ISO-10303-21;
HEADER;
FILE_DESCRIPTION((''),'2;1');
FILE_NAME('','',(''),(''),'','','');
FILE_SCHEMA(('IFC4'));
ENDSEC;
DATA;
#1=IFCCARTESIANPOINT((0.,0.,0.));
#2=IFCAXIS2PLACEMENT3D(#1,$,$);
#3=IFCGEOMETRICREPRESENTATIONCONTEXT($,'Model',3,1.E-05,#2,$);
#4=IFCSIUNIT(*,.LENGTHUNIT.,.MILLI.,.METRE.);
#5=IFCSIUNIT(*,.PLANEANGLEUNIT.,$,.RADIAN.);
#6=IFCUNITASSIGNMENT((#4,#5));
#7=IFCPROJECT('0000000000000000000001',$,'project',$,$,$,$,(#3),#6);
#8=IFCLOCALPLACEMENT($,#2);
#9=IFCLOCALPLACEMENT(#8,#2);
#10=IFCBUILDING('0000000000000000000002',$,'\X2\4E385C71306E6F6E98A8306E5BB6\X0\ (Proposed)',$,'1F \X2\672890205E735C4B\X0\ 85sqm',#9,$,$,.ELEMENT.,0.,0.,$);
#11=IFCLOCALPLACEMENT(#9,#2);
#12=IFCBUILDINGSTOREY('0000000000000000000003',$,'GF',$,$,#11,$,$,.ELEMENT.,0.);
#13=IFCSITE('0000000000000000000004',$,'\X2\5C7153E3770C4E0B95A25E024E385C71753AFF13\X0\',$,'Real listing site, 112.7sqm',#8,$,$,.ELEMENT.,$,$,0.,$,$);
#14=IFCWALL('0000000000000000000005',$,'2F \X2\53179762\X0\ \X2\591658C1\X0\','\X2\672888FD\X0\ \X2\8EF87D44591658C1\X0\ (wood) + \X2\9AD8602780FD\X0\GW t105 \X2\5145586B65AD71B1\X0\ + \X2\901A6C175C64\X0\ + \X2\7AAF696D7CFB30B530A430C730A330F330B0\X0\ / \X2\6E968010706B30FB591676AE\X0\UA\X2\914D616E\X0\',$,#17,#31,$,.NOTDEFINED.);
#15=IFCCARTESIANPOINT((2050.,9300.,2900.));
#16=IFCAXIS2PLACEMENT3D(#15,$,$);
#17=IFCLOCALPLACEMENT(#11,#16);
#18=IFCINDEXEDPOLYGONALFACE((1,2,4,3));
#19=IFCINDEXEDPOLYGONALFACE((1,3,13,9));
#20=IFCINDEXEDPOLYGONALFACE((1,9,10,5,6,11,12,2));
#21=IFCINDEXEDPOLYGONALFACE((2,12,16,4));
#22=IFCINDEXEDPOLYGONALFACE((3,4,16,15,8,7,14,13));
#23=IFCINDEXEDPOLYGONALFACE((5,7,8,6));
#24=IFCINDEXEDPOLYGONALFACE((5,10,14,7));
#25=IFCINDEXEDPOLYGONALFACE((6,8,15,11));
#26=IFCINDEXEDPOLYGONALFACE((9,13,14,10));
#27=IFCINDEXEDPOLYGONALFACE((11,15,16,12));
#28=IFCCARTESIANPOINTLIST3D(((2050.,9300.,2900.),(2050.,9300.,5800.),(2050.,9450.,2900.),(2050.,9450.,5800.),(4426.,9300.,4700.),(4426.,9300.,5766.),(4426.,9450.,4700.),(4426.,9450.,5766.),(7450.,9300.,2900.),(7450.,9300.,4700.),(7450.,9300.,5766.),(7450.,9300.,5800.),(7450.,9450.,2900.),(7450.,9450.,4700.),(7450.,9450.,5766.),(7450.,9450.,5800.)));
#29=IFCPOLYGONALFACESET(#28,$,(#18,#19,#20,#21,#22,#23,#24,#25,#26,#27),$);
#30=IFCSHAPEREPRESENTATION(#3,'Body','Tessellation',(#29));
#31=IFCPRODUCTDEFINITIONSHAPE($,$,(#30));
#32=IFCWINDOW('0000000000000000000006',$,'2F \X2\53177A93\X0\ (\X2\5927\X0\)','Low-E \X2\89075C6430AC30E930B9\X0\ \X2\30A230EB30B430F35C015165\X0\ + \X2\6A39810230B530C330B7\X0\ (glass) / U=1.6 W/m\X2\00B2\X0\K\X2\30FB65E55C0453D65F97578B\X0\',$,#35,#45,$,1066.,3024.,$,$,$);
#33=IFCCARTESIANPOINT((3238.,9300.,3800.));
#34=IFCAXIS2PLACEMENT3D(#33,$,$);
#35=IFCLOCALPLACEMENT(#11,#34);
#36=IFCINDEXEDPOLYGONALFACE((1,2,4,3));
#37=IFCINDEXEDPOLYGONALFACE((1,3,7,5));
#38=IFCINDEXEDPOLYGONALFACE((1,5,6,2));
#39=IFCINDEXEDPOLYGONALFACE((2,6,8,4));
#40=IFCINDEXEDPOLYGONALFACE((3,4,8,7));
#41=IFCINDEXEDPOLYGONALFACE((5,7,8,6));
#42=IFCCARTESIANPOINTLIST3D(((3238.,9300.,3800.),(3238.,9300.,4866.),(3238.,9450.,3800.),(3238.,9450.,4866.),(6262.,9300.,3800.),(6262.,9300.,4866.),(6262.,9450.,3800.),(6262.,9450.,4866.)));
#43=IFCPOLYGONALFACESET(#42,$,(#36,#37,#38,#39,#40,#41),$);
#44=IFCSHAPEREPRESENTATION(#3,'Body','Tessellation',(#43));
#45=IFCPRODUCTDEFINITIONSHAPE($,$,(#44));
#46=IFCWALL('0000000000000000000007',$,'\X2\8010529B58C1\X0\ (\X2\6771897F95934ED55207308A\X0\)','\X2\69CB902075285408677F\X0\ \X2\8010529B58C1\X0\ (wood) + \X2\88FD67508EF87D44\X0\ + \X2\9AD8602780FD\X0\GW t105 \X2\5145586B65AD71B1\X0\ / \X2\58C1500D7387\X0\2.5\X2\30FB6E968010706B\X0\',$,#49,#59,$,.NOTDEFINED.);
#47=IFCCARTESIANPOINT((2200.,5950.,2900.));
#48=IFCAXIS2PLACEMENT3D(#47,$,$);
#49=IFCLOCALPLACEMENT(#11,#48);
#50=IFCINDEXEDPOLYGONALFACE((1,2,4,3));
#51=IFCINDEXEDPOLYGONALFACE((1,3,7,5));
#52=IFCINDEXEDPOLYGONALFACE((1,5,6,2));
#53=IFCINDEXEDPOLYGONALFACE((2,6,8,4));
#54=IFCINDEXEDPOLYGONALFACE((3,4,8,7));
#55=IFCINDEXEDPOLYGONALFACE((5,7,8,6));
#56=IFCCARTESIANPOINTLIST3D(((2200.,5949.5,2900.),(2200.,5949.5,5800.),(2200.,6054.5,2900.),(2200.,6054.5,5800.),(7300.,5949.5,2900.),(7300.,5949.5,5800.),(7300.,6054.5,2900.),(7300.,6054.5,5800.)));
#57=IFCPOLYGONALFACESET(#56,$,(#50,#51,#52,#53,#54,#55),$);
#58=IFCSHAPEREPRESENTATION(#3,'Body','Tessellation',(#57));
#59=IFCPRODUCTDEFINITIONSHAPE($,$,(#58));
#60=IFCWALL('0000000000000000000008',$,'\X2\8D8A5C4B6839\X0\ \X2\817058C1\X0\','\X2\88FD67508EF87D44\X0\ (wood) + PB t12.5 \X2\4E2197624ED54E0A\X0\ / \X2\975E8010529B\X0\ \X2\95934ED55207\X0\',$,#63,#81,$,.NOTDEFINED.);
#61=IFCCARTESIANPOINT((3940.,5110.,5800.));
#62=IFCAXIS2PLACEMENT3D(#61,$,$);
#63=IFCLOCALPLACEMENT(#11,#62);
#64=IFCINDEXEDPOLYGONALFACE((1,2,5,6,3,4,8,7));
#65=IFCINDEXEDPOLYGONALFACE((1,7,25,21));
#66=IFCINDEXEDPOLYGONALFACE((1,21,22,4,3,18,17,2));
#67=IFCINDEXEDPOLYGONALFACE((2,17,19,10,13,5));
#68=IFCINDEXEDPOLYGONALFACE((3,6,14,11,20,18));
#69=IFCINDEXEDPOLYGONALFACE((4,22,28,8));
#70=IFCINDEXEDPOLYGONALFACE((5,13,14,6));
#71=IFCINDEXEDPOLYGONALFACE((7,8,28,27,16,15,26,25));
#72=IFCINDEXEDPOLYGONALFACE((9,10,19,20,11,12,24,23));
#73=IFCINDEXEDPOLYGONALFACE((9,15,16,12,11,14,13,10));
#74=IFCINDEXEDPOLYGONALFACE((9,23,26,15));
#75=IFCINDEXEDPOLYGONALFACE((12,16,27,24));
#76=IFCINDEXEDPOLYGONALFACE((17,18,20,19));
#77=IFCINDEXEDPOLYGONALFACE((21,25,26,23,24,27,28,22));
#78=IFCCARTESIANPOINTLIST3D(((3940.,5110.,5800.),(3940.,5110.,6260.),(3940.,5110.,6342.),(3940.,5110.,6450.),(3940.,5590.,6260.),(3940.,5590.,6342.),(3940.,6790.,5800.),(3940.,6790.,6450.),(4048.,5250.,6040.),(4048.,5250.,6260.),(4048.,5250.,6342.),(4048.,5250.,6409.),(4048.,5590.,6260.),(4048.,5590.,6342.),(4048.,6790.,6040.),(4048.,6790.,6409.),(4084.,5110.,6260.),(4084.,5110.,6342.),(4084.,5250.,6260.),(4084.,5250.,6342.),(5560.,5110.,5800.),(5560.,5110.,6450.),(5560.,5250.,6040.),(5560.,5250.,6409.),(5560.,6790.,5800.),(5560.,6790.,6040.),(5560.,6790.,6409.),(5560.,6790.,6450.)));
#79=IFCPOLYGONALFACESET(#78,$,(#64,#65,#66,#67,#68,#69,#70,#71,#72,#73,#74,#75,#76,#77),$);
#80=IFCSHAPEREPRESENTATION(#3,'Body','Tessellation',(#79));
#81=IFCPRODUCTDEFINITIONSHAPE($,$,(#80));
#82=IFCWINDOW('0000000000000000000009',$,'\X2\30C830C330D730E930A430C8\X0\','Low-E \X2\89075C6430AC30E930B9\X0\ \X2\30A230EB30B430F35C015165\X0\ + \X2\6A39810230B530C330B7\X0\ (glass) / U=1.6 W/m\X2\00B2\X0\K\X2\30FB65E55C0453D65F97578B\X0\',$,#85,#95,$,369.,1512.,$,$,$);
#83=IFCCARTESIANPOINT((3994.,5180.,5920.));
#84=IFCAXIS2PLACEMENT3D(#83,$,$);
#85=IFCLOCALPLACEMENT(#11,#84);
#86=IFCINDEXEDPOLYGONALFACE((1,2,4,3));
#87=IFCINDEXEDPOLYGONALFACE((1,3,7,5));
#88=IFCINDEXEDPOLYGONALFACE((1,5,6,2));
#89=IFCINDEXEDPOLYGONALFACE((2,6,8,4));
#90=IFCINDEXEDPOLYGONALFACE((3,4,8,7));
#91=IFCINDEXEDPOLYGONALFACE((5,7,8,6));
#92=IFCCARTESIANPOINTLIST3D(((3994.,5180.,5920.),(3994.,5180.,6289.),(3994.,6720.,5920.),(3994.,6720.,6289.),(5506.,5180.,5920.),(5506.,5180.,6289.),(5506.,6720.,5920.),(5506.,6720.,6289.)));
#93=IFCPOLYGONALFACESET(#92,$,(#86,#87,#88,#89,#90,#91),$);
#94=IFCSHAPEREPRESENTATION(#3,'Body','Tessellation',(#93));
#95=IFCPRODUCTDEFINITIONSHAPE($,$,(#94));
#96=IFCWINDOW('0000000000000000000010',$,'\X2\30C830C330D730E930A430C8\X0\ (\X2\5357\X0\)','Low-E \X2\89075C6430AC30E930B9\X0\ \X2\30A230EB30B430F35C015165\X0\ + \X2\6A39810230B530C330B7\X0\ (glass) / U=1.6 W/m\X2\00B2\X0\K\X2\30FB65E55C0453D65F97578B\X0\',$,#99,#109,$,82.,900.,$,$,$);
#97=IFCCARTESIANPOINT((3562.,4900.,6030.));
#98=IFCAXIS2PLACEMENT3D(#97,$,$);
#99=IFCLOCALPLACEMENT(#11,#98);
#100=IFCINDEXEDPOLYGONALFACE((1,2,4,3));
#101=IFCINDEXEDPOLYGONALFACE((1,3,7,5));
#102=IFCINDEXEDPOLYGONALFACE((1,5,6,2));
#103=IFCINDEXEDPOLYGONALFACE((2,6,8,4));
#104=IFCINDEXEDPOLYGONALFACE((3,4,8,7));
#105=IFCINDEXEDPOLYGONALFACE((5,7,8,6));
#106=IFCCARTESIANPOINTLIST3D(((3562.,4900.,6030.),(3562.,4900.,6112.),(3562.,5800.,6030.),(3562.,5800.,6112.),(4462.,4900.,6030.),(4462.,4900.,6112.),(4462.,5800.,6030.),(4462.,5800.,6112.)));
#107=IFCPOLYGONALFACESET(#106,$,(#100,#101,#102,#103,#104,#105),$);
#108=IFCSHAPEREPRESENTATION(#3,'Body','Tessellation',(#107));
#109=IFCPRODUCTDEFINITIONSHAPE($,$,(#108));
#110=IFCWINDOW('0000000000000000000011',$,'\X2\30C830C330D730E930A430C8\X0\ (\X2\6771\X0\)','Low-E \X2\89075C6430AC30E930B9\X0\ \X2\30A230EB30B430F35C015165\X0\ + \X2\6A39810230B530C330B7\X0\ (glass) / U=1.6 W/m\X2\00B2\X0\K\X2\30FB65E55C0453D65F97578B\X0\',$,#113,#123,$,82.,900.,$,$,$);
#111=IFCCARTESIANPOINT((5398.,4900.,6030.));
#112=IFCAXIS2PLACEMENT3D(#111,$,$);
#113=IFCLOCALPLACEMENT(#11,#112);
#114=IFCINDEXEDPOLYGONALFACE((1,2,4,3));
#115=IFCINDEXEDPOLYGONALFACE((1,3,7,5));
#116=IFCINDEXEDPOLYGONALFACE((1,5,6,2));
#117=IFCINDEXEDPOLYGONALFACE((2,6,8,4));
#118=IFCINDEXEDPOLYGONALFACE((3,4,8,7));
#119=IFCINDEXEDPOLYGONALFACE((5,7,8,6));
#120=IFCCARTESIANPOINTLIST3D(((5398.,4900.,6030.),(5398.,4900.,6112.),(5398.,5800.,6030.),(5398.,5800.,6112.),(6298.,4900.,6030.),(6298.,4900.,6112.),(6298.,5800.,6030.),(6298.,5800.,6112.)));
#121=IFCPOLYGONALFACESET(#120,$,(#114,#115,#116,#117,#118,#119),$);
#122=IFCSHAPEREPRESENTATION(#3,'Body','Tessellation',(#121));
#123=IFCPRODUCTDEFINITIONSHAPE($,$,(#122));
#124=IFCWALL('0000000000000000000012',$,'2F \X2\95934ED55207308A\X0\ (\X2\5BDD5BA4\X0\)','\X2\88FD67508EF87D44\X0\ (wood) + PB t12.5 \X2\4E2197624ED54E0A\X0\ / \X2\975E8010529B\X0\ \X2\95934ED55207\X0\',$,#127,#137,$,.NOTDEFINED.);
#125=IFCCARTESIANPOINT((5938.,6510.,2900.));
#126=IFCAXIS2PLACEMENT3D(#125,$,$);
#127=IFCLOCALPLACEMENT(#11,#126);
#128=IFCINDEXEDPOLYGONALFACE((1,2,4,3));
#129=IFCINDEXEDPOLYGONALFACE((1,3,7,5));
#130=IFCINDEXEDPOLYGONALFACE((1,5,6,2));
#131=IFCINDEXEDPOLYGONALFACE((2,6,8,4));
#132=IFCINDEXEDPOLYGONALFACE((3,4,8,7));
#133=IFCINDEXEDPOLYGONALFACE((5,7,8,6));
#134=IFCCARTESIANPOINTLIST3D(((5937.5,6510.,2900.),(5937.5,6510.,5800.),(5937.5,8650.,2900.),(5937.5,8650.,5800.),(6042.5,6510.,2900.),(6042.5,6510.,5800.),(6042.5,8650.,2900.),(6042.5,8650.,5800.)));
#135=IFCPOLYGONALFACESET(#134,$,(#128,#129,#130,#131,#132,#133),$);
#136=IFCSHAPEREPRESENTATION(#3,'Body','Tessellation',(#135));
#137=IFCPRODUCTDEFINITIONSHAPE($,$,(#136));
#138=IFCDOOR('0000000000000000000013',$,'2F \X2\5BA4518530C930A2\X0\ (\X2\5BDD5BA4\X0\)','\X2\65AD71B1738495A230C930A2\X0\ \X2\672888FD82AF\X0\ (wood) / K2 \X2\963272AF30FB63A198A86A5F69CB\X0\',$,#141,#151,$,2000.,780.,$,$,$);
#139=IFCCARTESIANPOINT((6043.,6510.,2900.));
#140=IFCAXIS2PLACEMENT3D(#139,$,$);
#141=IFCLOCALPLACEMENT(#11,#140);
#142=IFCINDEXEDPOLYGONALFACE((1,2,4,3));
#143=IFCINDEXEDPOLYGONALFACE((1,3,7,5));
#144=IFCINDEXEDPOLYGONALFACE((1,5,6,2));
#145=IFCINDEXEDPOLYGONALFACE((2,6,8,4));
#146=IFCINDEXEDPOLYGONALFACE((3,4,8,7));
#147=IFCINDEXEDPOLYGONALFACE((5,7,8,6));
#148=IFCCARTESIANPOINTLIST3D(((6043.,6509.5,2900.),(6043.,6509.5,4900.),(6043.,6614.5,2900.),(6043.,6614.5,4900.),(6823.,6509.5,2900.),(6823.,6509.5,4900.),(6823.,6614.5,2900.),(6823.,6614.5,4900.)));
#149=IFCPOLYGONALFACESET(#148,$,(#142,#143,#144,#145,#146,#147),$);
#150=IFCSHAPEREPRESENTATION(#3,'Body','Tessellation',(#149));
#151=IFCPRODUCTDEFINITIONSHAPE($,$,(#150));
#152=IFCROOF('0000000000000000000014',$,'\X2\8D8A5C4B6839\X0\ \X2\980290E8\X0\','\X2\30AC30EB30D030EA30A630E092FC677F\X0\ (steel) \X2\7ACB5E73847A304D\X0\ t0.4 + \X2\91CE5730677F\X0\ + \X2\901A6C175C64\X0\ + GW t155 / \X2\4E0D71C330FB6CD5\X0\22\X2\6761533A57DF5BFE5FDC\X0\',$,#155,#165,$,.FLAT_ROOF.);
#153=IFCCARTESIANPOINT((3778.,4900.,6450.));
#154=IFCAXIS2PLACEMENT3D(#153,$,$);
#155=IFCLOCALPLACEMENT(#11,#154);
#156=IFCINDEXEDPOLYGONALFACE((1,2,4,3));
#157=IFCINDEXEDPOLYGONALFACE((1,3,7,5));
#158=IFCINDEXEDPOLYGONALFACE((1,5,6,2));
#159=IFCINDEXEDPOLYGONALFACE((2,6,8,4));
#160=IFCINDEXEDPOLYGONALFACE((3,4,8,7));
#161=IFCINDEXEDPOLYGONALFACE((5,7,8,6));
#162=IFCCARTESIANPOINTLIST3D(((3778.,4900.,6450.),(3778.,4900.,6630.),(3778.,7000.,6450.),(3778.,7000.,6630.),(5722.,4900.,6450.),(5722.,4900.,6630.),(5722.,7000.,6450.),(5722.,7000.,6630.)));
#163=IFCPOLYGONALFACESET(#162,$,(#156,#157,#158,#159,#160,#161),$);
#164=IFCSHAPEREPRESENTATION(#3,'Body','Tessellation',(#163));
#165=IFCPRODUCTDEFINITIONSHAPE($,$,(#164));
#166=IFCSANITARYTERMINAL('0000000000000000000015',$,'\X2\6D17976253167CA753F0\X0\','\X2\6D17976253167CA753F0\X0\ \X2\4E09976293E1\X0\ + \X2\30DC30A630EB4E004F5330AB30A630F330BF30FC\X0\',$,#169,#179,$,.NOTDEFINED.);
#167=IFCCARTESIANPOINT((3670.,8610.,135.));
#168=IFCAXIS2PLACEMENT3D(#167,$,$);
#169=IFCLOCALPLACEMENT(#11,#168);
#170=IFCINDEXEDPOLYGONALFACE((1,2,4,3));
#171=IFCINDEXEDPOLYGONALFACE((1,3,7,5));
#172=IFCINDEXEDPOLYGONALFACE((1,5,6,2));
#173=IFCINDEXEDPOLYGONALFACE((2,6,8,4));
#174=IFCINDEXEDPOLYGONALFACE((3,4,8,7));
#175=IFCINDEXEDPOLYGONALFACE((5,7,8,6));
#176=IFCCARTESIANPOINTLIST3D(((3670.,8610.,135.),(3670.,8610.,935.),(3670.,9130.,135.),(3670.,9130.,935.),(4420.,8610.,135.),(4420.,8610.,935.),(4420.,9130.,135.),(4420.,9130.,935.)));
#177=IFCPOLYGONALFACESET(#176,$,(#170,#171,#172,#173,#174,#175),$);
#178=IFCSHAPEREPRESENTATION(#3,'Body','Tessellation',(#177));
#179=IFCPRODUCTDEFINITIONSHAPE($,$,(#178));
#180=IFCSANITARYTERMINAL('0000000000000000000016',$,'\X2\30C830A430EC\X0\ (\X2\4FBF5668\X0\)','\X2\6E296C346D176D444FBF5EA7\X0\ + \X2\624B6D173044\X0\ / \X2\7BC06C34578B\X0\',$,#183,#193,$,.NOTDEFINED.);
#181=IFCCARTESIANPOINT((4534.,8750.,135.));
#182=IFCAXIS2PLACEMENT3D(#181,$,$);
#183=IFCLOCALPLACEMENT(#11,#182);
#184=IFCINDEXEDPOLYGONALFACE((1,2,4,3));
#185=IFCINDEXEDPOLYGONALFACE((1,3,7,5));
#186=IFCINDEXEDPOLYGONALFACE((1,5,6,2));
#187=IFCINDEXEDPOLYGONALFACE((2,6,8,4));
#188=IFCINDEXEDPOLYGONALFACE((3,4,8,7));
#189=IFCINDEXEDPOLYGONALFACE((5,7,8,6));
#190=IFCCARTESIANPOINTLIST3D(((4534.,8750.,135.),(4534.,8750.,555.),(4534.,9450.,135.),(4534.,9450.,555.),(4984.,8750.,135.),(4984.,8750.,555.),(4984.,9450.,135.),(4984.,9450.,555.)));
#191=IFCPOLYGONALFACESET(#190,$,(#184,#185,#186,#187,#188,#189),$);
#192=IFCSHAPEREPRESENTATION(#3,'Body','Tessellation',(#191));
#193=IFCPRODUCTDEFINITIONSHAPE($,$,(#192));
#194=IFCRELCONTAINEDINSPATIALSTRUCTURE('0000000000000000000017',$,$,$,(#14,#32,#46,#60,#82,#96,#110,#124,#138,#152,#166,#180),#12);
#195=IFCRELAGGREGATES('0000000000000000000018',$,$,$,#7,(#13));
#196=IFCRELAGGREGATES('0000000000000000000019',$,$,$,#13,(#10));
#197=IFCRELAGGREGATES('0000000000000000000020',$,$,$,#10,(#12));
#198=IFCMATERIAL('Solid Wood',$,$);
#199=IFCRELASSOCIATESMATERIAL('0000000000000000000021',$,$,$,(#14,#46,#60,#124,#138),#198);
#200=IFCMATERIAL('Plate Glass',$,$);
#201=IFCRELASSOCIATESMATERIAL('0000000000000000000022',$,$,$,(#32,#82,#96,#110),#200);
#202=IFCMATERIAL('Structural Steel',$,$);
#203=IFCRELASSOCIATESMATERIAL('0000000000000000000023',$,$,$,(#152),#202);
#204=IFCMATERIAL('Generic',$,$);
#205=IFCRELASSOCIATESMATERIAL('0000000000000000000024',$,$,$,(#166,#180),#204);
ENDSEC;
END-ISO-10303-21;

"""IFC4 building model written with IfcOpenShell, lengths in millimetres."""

from ifc_helpers import new_model, si_unit, frame, frame_2d, origin, place, context, project, spatial, rectangle, extrude, material, element, fill, save


model = new_model("IFC4")

# Units and contexts
model_context = context("Model", 3, precision=1e-05, world=origin())
ifc_project = project(units=[si_unit("LENGTHUNIT", "METRE", prefix="MILLI"), si_unit("PLANEANGLEUNIT", "RADIAN")], contexts=[model_context])

# Site, building, storey
site_placement = place(None, origin())
site = spatial("IfcSite", under=ifc_project, at=site_placement, Name="山口県下関市丸山町３", ObjectType="Real listing site, 112.7sqm", CompositionType="ELEMENT", RefElevation=0.0)
building_placement = place(site_placement, origin())
building = spatial("IfcBuilding", under=site, at=building_placement, Name="丸山の潮風の家 (Proposed)", ObjectType="1F 木造平屋 85sqm", CompositionType="ELEMENT", ElevationOfRefHeight=0.0, ElevationOfTerrain=0.0)
storey_placement = place(building_placement, origin())
storey = spatial("IfcBuildingStorey", under=building, at=storey_placement, Name="GF", CompositionType="ELEMENT", Elevation=0.0)

# Wall, opening, window
ifc_material_1 = material(Name="Solid Wood")
wall_1_placement = place(storey_placement, frame((2050.0, 9300.0, 2900.0)))
wall_1 = element("IfcWall", 1, at=wall_1_placement, inside=storey, material=ifc_material_1, Name="2F 北面 外壁", Description="木製 軸組外壁 (wood) + 高性能GW t105 充填断熱 + 通気層 + 窯業系サイディング / 準耐火・外皮UA配慮", PredefinedType="NOTDEFINED", context=model_context, shape_type="SweptSolid", body=[
    extrude(rectangle(XDim=5400.0, YDim=150.0, at=frame_2d((2700.0, 75.0))), frame((2050.0, 9300.0, 2900.0)), (0.0, 0.0, 1.0), 2900.0),
])
opening_1_placement = place(storey_placement, frame((3238.0, 9300.0, 3800.0)))
opening_1 = element("IfcOpeningElement", 2, at=opening_1_placement, cuts=wall_1, PredefinedType="NOTDEFINED", context=model_context, shape_type="SweptSolid", body=[
    extrude(rectangle(XDim=3024.0, YDim=150.0, at=frame_2d((1512.0, 75.0))), frame((3238.0, 9300.0, 3800.0)), (0.0, 0.0, 1.0), 1066.0),
])
ifc_material_2 = material(Name="Plate Glass")
window_1_placement = place(storey_placement, frame((3238.0, 9300.0, 3800.0)))
window_1 = element("IfcWindow", 3, at=window_1_placement, inside=storey, material=ifc_material_2, Name="2F 北窓 (大)", Description="Low-E 複層ガラス アルゴン封入 + 樹脂サッシ (glass) / U=1.6 W/m²K・日射取得型", OverallHeight=1066.0, OverallWidth=3024.0, context=model_context, shape_type="SweptSolid", body=[
    extrude(rectangle(XDim=3024.0, YDim=150.0, at=frame_2d((1512.0, 75.0))), frame((3238.0, 9300.0, 3800.0)), (0.0, 0.0, 1.0), 1066.0),
])
fill(opening_1, window_1)

# Wall
wall_2_placement = place(storey_placement, frame((2200.0, 5950.0, 2900.0)))
element("IfcWall", 4, at=wall_2_placement, inside=storey, material=ifc_material_1, Name="耐力壁 (東西間仕切り)", Description="構造用合板 耐力壁 (wood) + 製材軸組 + 高性能GW t105 充填断熱 / 壁倍率2.5・準耐火", PredefinedType="NOTDEFINED", context=model_context, shape_type="SweptSolid", body=[
    extrude(rectangle(XDim=5100.0, YDim=105.0, at=frame_2d((2550.0, 52.0))), frame((2200.0, 5950.0, 2900.0)), (0.0, 0.0, 1.0), 2900.0),
])

# Wall, openings, windows
wall_3_placement = place(storey_placement, frame((3940.0, 5110.0, 5800.0)))
wall_3 = element("IfcWall", 5, at=wall_3_placement, inside=storey, material=ifc_material_1, Name="越屋根 腰壁", Description="製材軸組 (wood) + PB t12.5 両面仕上 / 非耐力 間仕切", PredefinedType="NOTDEFINED", context=model_context, shape_type="SweptSolid", body=[
    extrude(rectangle(XDim=1620.0, YDim=1680.0, at=frame_2d((810.0, 840.0))), frame((3940.0, 5110.0, 5800.0)), (0.0, 0.0, 1.0), 650.0),
])
opening_2_placement = place(storey_placement, frame((3994.0, 5180.0, 5920.0)))
opening_2 = element("IfcOpeningElement", 6, at=opening_2_placement, cuts=wall_3, PredefinedType="NOTDEFINED", context=model_context, shape_type="SweptSolid", body=[
    extrude(rectangle(XDim=1512.0, YDim=1540.0, at=frame_2d((756.0, 770.0))), frame((3994.0, 5180.0, 5920.0)), (0.0, 0.0, 1.0), 369.0),
])
opening_3_placement = place(storey_placement, frame((3562.0, 4900.0, 6030.0)))
opening_3 = element("IfcOpeningElement", 7, at=opening_3_placement, cuts=wall_3, PredefinedType="NOTDEFINED", context=model_context, shape_type="SweptSolid", body=[
    extrude(rectangle(XDim=900.0, YDim=900.0, at=frame_2d((450.0, 450.0))), frame((3562.0, 4900.0, 6030.0)), (0.0, 0.0, 1.0), 82.0),
])
opening_4_placement = place(storey_placement, frame((5398.0, 4900.0, 6030.0)))
opening_4 = element("IfcOpeningElement", 8, at=opening_4_placement, cuts=wall_3, PredefinedType="NOTDEFINED", context=model_context, shape_type="SweptSolid", body=[
    extrude(rectangle(XDim=900.0, YDim=900.0, at=frame_2d((450.0, 450.0))), frame((5398.0, 4900.0, 6030.0)), (0.0, 0.0, 1.0), 82.0),
])
window_2_placement = place(storey_placement, frame((3994.0, 5180.0, 5920.0)))
window_2 = element("IfcWindow", 9, at=window_2_placement, inside=storey, material=ifc_material_2, Name="トップライト", Description="Low-E 複層ガラス アルゴン封入 + 樹脂サッシ (glass) / U=1.6 W/m²K・日射取得型", OverallHeight=369.0, OverallWidth=1512.0, context=model_context, shape_type="SweptSolid", body=[
    extrude(rectangle(XDim=1512.0, YDim=1540.0, at=frame_2d((756.0, 770.0))), frame((3994.0, 5180.0, 5920.0)), (0.0, 0.0, 1.0), 369.0),
])
fill(opening_2, window_2)
window_3_placement = place(storey_placement, frame((3562.0, 4900.0, 6030.0)))
window_3 = element("IfcWindow", 10, at=window_3_placement, inside=storey, material=ifc_material_2, Name="トップライト (南)", Description="Low-E 複層ガラス アルゴン封入 + 樹脂サッシ (glass) / U=1.6 W/m²K・日射取得型", OverallHeight=82.0, OverallWidth=900.0, context=model_context, shape_type="SweptSolid", body=[
    extrude(rectangle(XDim=900.0, YDim=900.0, at=frame_2d((450.0, 450.0))), frame((3562.0, 4900.0, 6030.0)), (0.0, 0.0, 1.0), 82.0),
])
fill(opening_3, window_3)
window_4_placement = place(storey_placement, frame((5398.0, 4900.0, 6030.0)))
window_4 = element("IfcWindow", 11, at=window_4_placement, inside=storey, material=ifc_material_2, Name="トップライト (東)", Description="Low-E 複層ガラス アルゴン封入 + 樹脂サッシ (glass) / U=1.6 W/m²K・日射取得型", OverallHeight=82.0, OverallWidth=900.0, context=model_context, shape_type="SweptSolid", body=[
    extrude(rectangle(XDim=900.0, YDim=900.0, at=frame_2d((450.0, 450.0))), frame((5398.0, 4900.0, 6030.0)), (0.0, 0.0, 1.0), 82.0),
])
fill(opening_4, window_4)

# Wall
wall_4_placement = place(storey_placement, frame((5938.0, 6510.0, 2900.0)))
element("IfcWall", 12, at=wall_4_placement, inside=storey, material=ifc_material_1, Name="2F 間仕切り (寝室)", Description="製材軸組 (wood) + PB t12.5 両面仕上 / 非耐力 間仕切", PredefinedType="NOTDEFINED", context=model_context, shape_type="SweptSolid", body=[
    extrude(rectangle(XDim=105.0, YDim=2140.0, at=frame_2d((52.0, 1070.0))), frame((5938.0, 6510.0, 2900.0)), (0.0, 0.0, 1.0), 2900.0),
])

# Door
door_placement = place(storey_placement, frame((6043.0, 6510.0, 2900.0)))
element("IfcDoor", 13, at=door_placement, inside=storey, material=ifc_material_1, Name="2F 室内ドア (寝室)", Description="断熱玄関ドア 木製芯 (wood) / K2 防犯・採風機構", OverallHeight=2000.0, OverallWidth=780.0, context=model_context, shape_type="SweptSolid", body=[
    extrude(rectangle(XDim=780.0, YDim=105.0, at=frame_2d((390.0, 52.0))), frame((6043.0, 6510.0, 2900.0)), (0.0, 0.0, 1.0), 2000.0),
])

# Roof
ifc_material_3 = material(Name="Structural Steel")
roof_placement = place(storey_placement, frame((3778.0, 4900.0, 6450.0)))
element("IfcRoof", 14, at=roof_placement, inside=storey, material=ifc_material_3, Name="越屋根 頂部", Description="ガルバリウム鋼板 (steel) 立平葺き t0.4 + 野地板 + 通気層 + GW t155 / 不燃・法22条区域対応", PredefinedType="FLAT_ROOF", context=model_context, shape_type="SweptSolid", body=[
    extrude(rectangle(XDim=1944.0, YDim=2100.0, at=frame_2d((972.0, 1050.0))), frame((3778.0, 4900.0, 6450.0)), (0.0, 0.0, 1.0), 180.0),
])

# Sanitary terminals
ifc_material_4 = material(Name="Generic")
sanitary_terminal_1_placement = place(storey_placement, frame((3670.0, 8610.0, 135.0)))
element("IfcSanitaryTerminal", 15, at=sanitary_terminal_1_placement, inside=storey, material=ifc_material_4, Name="洗面化粧台", Description="洗面化粧台 三面鏡 + ボウル一体カウンター", PredefinedType="NOTDEFINED", context=model_context, shape_type="SweptSolid", body=[
    extrude(rectangle(XDim=750.0, YDim=520.0, at=frame_2d((375.0, 260.0))), frame((3670.0, 8610.0, 135.0)), (0.0, 0.0, 1.0), 800.0),
])
sanitary_terminal_2_placement = place(storey_placement, frame((4534.0, 8750.0, 135.0)))
element("IfcSanitaryTerminal", 16, at=sanitary_terminal_2_placement, inside=storey, material=ifc_material_4, Name="トイレ (便器)", Description="温水洗浄便座 + 手洗い / 節水型", PredefinedType="NOTDEFINED", context=model_context, shape_type="SweptSolid", body=[
    extrude(rectangle(XDim=450.0, YDim=700.0, at=frame_2d((225.0, 350.0))), frame((4534.0, 8750.0, 135.0)), (0.0, 0.0, 1.0), 420.0),
])

save(model, "model.ifc")
